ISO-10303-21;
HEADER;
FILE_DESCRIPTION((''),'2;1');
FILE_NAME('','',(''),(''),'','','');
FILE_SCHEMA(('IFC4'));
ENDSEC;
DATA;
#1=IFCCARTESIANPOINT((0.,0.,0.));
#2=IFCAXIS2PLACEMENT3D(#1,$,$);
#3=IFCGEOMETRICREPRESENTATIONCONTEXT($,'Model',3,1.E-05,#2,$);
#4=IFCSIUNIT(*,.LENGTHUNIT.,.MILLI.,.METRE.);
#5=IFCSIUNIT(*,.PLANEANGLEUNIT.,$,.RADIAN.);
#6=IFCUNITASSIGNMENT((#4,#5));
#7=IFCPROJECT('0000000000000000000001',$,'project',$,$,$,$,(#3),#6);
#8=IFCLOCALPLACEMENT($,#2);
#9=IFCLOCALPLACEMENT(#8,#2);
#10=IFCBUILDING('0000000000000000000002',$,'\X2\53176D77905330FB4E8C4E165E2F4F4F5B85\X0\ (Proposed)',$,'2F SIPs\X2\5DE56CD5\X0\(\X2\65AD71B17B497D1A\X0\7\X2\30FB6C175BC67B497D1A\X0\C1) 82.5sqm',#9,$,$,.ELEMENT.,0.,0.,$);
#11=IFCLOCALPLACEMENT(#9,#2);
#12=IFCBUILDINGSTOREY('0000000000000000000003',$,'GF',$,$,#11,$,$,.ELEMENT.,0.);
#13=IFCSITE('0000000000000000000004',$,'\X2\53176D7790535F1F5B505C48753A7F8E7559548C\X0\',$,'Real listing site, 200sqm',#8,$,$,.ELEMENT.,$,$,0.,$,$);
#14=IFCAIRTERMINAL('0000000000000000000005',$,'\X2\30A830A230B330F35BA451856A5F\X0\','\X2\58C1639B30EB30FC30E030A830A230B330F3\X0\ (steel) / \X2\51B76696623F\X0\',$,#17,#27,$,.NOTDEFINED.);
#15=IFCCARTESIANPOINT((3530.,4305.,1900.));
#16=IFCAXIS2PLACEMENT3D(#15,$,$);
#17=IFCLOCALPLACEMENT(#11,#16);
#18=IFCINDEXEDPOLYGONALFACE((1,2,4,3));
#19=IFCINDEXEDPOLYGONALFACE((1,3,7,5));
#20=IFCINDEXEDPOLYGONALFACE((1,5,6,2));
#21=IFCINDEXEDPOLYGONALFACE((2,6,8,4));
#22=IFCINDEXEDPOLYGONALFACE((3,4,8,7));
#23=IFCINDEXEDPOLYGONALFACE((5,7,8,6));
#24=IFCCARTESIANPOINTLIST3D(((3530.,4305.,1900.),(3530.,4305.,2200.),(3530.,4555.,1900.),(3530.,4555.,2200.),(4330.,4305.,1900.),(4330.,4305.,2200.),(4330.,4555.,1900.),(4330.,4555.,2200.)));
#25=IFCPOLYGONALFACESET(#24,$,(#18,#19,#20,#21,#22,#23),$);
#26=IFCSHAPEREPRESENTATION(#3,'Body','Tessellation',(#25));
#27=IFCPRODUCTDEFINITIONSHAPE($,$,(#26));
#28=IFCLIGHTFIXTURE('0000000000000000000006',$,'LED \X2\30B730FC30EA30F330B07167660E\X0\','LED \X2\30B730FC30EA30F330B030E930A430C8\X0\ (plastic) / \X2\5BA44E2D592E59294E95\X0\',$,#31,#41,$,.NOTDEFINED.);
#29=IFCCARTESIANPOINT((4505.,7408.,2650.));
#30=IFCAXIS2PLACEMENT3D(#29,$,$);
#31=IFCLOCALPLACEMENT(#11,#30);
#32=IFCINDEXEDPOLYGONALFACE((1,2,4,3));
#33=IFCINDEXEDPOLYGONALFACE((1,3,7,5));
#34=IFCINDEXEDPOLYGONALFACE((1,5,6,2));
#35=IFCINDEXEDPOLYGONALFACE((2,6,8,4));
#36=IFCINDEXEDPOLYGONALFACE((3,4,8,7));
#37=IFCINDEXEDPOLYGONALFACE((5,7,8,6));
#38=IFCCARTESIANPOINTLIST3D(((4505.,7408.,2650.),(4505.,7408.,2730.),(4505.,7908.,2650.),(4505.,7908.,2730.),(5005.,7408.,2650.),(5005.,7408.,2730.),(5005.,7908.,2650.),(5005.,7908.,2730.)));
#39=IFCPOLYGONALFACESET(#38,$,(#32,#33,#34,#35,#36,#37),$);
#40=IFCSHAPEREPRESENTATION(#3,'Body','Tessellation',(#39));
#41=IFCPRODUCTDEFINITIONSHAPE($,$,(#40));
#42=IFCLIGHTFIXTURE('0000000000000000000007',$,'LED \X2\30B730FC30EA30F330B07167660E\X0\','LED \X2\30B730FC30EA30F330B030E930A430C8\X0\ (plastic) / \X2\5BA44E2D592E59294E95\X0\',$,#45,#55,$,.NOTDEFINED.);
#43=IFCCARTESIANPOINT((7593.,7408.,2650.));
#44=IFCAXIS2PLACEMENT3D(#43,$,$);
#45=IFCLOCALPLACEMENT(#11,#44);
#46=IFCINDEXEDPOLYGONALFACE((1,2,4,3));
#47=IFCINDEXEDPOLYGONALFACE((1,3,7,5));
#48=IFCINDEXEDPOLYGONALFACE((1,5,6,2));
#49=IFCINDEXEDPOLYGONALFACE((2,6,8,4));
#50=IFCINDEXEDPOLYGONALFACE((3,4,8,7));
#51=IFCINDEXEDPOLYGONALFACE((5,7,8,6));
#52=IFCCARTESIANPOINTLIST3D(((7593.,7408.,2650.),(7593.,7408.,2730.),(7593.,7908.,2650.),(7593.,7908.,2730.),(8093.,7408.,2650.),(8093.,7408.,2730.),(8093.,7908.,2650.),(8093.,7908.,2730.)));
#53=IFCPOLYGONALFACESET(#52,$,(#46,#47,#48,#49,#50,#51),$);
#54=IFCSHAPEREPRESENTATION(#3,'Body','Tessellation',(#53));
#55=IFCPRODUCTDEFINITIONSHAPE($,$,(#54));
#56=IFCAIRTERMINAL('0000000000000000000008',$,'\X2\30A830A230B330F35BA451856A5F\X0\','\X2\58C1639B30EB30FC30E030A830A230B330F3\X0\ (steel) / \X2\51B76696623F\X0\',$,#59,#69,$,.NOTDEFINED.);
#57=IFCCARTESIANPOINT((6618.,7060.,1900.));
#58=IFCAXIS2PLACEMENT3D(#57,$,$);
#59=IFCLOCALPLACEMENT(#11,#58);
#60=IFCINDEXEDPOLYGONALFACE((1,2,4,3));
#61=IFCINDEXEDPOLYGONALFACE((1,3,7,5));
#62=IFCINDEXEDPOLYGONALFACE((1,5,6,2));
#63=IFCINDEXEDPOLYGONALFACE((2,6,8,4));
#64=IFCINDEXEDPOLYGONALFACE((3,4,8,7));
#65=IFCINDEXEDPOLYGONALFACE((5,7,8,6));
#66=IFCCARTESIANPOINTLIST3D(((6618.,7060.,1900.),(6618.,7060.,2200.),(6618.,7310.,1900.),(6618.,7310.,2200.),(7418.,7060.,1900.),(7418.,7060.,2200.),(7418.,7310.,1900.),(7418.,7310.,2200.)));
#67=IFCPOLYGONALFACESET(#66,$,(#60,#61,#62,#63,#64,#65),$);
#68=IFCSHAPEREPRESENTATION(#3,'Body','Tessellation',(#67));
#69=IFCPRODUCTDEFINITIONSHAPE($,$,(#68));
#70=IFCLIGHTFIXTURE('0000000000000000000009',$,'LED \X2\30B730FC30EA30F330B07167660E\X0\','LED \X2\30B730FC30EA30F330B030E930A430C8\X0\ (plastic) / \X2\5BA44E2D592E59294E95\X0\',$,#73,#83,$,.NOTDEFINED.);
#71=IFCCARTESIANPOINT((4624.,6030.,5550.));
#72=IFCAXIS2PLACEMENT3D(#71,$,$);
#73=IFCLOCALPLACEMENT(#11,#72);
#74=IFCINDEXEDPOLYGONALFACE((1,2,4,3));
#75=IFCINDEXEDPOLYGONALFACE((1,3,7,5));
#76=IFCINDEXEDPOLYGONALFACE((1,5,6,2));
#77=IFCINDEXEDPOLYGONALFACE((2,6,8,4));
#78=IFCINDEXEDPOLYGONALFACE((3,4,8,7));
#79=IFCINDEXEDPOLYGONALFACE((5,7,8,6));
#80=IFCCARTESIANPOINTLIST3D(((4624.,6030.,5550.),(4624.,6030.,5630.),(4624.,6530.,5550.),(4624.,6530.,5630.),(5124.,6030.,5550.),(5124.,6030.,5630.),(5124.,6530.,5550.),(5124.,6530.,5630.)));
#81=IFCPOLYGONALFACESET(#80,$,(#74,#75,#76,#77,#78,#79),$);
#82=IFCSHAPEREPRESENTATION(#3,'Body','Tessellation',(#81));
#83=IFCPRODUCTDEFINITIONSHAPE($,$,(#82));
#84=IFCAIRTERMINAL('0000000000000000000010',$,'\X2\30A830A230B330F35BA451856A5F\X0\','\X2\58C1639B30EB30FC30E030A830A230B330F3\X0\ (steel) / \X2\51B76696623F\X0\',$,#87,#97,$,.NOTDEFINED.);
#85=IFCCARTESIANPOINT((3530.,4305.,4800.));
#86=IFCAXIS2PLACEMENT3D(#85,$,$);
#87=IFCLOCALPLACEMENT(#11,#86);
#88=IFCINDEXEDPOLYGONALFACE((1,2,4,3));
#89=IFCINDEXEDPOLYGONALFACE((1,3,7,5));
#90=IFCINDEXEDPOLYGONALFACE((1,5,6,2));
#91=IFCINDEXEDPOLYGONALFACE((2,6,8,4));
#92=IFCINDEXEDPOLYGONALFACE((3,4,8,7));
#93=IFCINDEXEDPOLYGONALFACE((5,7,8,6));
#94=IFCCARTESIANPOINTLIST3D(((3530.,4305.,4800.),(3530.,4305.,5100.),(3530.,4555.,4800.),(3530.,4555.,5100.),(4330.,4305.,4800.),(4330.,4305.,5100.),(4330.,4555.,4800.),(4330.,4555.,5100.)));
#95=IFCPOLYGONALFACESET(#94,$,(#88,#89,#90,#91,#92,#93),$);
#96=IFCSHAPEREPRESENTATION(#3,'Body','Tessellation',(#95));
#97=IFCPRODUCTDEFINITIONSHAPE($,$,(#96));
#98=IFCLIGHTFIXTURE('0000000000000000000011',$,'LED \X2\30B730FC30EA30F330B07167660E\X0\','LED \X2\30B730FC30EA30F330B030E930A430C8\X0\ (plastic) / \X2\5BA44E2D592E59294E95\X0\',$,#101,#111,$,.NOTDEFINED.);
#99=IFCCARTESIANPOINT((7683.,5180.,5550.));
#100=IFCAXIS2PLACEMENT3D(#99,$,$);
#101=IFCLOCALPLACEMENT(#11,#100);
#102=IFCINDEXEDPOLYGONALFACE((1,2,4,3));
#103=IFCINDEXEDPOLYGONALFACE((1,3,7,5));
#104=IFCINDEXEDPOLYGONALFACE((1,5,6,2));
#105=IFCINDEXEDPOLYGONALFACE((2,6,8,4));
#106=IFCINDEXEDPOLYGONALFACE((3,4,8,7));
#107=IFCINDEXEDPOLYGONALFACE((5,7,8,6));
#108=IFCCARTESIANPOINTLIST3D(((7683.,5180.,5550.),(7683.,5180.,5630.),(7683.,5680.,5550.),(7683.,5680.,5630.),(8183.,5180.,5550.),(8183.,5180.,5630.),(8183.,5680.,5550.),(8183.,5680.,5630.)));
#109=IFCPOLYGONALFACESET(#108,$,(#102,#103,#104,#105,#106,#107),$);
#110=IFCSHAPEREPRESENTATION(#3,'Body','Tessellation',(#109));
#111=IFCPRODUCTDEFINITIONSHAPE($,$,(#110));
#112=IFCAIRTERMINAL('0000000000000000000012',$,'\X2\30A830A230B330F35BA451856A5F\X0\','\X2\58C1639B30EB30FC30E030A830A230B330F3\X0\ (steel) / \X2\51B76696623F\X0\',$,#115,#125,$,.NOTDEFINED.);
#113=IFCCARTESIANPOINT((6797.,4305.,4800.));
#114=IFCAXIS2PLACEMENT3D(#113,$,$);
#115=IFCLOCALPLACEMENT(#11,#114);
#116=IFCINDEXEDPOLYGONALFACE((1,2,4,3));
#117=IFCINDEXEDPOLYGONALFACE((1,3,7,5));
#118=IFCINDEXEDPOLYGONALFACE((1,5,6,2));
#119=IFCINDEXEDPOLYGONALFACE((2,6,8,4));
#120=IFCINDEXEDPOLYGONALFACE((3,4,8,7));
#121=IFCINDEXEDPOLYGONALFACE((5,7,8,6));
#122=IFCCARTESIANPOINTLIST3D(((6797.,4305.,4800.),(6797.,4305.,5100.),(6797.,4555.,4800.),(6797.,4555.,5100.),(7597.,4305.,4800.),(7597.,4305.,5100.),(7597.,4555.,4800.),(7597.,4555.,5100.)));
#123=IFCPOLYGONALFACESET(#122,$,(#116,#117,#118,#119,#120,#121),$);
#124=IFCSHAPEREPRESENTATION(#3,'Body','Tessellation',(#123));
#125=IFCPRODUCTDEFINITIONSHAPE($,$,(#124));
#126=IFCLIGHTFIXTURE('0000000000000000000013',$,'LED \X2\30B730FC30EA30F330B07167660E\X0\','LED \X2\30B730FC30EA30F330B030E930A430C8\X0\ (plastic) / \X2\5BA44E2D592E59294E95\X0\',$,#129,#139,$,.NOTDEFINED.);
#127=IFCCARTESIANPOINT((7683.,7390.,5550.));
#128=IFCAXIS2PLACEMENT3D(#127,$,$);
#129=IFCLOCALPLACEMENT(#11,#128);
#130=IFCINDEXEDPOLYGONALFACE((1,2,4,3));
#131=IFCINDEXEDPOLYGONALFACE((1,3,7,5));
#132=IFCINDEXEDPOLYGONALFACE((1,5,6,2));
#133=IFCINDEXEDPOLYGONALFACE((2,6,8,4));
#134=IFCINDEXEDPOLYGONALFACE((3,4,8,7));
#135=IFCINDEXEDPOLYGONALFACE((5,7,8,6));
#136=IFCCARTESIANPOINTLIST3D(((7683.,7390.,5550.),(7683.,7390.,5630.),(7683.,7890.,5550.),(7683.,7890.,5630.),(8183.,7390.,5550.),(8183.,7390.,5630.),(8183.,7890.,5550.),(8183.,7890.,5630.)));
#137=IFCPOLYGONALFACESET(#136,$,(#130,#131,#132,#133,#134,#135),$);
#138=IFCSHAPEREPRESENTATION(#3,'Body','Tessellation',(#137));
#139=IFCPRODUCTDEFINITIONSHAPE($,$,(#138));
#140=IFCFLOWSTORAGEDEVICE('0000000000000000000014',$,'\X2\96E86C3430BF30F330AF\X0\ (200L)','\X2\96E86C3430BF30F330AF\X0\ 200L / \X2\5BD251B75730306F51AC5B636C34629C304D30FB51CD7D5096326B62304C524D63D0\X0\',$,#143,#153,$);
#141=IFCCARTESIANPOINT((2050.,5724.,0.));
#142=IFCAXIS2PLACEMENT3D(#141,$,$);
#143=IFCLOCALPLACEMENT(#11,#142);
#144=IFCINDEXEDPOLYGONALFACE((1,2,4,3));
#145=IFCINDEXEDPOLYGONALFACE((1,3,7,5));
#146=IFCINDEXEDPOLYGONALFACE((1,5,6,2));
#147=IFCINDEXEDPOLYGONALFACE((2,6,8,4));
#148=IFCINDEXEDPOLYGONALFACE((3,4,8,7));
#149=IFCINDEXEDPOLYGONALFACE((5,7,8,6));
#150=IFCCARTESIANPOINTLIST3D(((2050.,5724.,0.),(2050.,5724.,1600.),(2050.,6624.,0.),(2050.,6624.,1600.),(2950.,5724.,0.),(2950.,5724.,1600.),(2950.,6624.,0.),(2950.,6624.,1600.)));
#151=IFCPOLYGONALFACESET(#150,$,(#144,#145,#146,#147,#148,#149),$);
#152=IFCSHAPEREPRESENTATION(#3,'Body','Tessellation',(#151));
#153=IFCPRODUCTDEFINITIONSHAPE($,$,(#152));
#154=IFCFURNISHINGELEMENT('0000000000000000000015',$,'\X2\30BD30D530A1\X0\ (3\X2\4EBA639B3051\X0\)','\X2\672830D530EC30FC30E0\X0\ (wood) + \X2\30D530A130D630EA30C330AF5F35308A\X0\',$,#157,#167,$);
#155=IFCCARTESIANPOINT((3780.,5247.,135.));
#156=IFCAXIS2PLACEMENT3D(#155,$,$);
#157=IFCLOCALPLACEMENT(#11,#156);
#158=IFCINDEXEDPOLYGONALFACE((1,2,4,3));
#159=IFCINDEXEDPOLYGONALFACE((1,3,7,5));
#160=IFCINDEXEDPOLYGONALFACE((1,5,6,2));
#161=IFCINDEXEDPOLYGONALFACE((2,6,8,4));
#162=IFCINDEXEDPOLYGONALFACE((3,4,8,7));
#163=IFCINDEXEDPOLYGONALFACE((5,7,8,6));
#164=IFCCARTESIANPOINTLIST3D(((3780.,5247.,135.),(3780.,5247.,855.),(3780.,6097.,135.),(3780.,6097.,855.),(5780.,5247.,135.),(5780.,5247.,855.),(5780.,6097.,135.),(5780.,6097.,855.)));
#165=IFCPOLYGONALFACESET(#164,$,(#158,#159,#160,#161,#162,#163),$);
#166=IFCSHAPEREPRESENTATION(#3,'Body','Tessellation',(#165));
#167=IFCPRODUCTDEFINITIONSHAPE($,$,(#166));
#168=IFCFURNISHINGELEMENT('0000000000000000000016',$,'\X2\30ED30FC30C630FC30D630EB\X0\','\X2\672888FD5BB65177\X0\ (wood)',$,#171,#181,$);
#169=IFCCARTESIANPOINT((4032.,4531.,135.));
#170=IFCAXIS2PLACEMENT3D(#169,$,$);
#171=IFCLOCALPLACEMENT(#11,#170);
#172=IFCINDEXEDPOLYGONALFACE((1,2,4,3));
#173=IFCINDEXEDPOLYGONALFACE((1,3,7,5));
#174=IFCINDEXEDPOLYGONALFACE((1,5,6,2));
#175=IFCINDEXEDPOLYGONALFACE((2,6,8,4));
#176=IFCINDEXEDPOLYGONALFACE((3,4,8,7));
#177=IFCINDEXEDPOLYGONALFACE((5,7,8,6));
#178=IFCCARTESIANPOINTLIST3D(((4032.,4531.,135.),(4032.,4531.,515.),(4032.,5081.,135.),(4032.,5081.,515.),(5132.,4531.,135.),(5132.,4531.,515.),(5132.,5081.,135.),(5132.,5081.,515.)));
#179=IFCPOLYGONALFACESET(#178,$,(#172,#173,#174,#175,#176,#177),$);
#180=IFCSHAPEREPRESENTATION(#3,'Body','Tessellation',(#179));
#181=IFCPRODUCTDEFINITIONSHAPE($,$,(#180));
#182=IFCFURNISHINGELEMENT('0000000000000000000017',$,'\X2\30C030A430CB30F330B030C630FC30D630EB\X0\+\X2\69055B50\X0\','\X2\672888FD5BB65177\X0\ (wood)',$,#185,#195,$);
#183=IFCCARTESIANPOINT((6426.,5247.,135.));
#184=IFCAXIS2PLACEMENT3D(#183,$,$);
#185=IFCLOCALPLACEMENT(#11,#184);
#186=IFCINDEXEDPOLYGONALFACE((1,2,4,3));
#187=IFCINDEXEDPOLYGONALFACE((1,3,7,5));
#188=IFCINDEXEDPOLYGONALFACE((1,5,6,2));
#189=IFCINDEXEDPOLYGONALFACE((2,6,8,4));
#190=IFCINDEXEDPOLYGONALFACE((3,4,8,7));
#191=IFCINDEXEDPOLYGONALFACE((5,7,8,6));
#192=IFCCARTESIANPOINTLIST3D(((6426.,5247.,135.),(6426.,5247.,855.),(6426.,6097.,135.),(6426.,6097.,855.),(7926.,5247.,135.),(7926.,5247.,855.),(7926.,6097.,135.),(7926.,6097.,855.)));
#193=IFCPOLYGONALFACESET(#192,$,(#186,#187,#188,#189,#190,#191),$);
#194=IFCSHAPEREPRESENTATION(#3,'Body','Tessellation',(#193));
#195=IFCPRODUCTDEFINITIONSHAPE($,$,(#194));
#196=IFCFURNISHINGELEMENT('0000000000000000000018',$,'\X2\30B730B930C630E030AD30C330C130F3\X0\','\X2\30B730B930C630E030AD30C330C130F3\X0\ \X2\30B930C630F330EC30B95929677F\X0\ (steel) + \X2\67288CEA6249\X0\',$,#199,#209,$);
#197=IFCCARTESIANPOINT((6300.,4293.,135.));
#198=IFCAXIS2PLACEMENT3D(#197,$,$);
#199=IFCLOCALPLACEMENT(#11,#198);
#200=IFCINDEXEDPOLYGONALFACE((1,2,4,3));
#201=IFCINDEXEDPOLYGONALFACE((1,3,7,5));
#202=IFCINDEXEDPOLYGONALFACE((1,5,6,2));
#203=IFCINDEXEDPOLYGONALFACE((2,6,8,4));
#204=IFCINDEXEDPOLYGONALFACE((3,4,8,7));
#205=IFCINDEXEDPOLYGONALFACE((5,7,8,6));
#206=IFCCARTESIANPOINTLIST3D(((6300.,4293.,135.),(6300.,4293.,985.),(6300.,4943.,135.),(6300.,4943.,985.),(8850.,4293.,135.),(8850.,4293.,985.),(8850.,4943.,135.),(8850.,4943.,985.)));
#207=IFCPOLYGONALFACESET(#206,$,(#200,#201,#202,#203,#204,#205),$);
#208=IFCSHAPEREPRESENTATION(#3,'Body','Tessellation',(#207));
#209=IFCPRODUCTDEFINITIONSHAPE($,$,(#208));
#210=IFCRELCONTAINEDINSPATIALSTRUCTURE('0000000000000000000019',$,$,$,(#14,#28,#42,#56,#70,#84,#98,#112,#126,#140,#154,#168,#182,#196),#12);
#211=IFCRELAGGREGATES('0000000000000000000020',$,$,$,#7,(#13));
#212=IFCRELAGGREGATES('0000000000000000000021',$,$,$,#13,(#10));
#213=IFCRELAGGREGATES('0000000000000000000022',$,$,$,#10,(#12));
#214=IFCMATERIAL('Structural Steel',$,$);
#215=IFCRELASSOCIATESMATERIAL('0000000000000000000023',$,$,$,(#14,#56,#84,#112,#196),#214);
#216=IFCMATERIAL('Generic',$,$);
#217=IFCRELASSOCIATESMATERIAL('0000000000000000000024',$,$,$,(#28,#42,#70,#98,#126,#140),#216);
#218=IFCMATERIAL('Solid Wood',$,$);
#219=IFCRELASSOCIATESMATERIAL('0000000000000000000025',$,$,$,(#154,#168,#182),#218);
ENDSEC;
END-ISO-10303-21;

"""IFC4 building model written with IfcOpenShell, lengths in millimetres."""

from ifc_helpers import new_model, si_unit, frame, frame_2d, origin, place, context, project, spatial, rectangle, extrude, material, element, save


model = new_model("IFC4")

# Units and contexts
model_context = context("Model", 3, precision=1e-05, world=origin())
ifc_project = project(units=[si_unit("LENGTHUNIT", "METRE", prefix="MILLI"), si_unit("PLANEANGLEUNIT", "RADIAN")], contexts=[model_context])

# Site, building, storey
site_placement = place(None, origin())
site = spatial("IfcSite", under=ifc_project, at=site_placement, Name="北海道弟子屈町美留和", ObjectType="Real listing site, 200sqm", CompositionType="ELEMENT", RefElevation=0.0)
building_placement = place(site_placement, origin())
building = spatial("IfcBuilding", under=site, at=building_placement, Name="北海道・二世帯住宅 (Proposed)", ObjectType="2F SIPs工法(断熱等級7・気密等級C1) 82.5sqm", CompositionType="ELEMENT", ElevationOfRefHeight=0.0, ElevationOfTerrain=0.0)
storey_placement = place(building_placement, origin())
storey = spatial("IfcBuildingStorey", under=building, at=storey_placement, Name="GF", CompositionType="ELEMENT", Elevation=0.0)

# Shared definitions
ifc_material_1 = material(Name="Solid Wood")

# Shared definitions
ifc_material_2 = material(Name="Structural Steel")

# Shared definitions
ifc_material_3 = material(Name="Generic")

# Air terminal
air_terminal_1_placement = place(storey_placement, frame((3530.0, 4305.0, 1900.0)))
element("IfcAirTerminal", 1, at=air_terminal_1_placement, inside=storey, material=ifc_material_2, Name="エアコン室内機", Description="壁掛ルームエアコン (steel) / 冷暖房", PredefinedType="NOTDEFINED", context=model_context, shape_type="SweptSolid", body=[
    extrude(rectangle(XDim=800.0, YDim=250.0, at=frame_2d((400.0, 125.0))), frame((3530.0, 4305.0, 1900.0)), (0.0, 0.0, 1.0), 300.0),
])

# Light fixtures
light_fixture_1_placement = place(storey_placement, frame((4505.0, 7408.0, 2650.0)))
element("IfcLightFixture", 2, at=light_fixture_1_placement, inside=storey, material=ifc_material_3, Name="LED シーリング照明", Description="LED シーリングライト (plastic) / 室中央天井", PredefinedType="NOTDEFINED", context=model_context, shape_type="SweptSolid", body=[
    extrude(rectangle(XDim=500.0, YDim=500.0, at=frame_2d((250.0, 250.0))), frame((4505.0, 7408.0, 2650.0)), (0.0, 0.0, 1.0), 80.0),
])
light_fixture_2_placement = place(storey_placement, frame((7593.0, 7408.0, 2650.0)))
element("IfcLightFixture", 3, at=light_fixture_2_placement, inside=storey, material=ifc_material_3, Name="LED シーリング照明", Description="LED シーリングライト (plastic) / 室中央天井", PredefinedType="NOTDEFINED", context=model_context, shape_type="SweptSolid", body=[
    extrude(rectangle(XDim=500.0, YDim=500.0, at=frame_2d((250.0, 250.0))), frame((7593.0, 7408.0, 2650.0)), (0.0, 0.0, 1.0), 80.0),
])

# Air terminal
air_terminal_2_placement = place(storey_placement, frame((6618.0, 7060.0, 1900.0)))
element("IfcAirTerminal", 4, at=air_terminal_2_placement, inside=storey, material=ifc_material_2, Name="エアコン室内機", Description="壁掛ルームエアコン (steel) / 冷暖房", PredefinedType="NOTDEFINED", context=model_context, shape_type="SweptSolid", body=[
    extrude(rectangle(XDim=800.0, YDim=250.0, at=frame_2d((400.0, 125.0))), frame((6618.0, 7060.0, 1900.0)), (0.0, 0.0, 1.0), 300.0),
])

# Light fixture
light_fixture_3_placement = place(storey_placement, frame((4624.0, 6030.0, 5550.0)))
element("IfcLightFixture", 5, at=light_fixture_3_placement, inside=storey, material=ifc_material_3, Name="LED シーリング照明", Description="LED シーリングライト (plastic) / 室中央天井", PredefinedType="NOTDEFINED", context=model_context, shape_type="SweptSolid", body=[
    extrude(rectangle(XDim=500.0, YDim=500.0, at=frame_2d((250.0, 250.0))), frame((4624.0, 6030.0, 5550.0)), (0.0, 0.0, 1.0), 80.0),
])

# Air terminal
air_terminal_3_placement = place(storey_placement, frame((3530.0, 4305.0, 4800.0)))
element("IfcAirTerminal", 6, at=air_terminal_3_placement, inside=storey, material=ifc_material_2, Name="エアコン室内機", Description="壁掛ルームエアコン (steel) / 冷暖房", PredefinedType="NOTDEFINED", context=model_context, shape_type="SweptSolid", body=[
    extrude(rectangle(XDim=800.0, YDim=250.0, at=frame_2d((400.0, 125.0))), frame((3530.0, 4305.0, 4800.0)), (0.0, 0.0, 1.0), 300.0),
])

# Light fixture
light_fixture_4_placement = place(storey_placement, frame((7683.0, 5180.0, 5550.0)))
element("IfcLightFixture", 7, at=light_fixture_4_placement, inside=storey, material=ifc_material_3, Name="LED シーリング照明", Description="LED シーリングライト (plastic) / 室中央天井", PredefinedType="NOTDEFINED", context=model_context, shape_type="SweptSolid", body=[
    extrude(rectangle(XDim=500.0, YDim=500.0, at=frame_2d((250.0, 250.0))), frame((7683.0, 5180.0, 5550.0)), (0.0, 0.0, 1.0), 80.0),
])

# Air terminal
air_terminal_4_placement = place(storey_placement, frame((6797.0, 4305.0, 4800.0)))
element("IfcAirTerminal", 8, at=air_terminal_4_placement, inside=storey, material=ifc_material_2, Name="エアコン室内機", Description="壁掛ルームエアコン (steel) / 冷暖房", PredefinedType="NOTDEFINED", context=model_context, shape_type="SweptSolid", body=[
    extrude(rectangle(XDim=800.0, YDim=250.0, at=frame_2d((400.0, 125.0))), frame((6797.0, 4305.0, 4800.0)), (0.0, 0.0, 1.0), 300.0),
])

# Light fixture
light_fixture_5_placement = place(storey_placement, frame((7683.0, 7390.0, 5550.0)))
element("IfcLightFixture", 9, at=light_fixture_5_placement, inside=storey, material=ifc_material_3, Name="LED シーリング照明", Description="LED シーリングライト (plastic) / 室中央天井", PredefinedType="NOTDEFINED", context=model_context, shape_type="SweptSolid", body=[
    extrude(rectangle(XDim=500.0, YDim=500.0, at=frame_2d((250.0, 250.0))), frame((7683.0, 7390.0, 5550.0)), (0.0, 0.0, 1.0), 80.0),
])

# Flow storage device
flow_storage_device_1_placement = place(storey_placement, frame((2050.0, 5724.0, 0.0)))
element("IfcFlowStorageDevice", 10, at=flow_storage_device_1_placement, inside=storey, material=ifc_material_3, Name="雨水タンク (200L)", Description="雨水タンク 200L / 寒冷地は冬季水抜き・凍結防止が前提", context=model_context, shape_type="SweptSolid", body=[
    extrude(rectangle(XDim=900.0, YDim=900.0, at=frame_2d((450.0, 450.0))), frame((2050.0, 5724.0, 0.0)), (0.0, 0.0, 1.0), 1600.0),
])

# Furnishing elements
furnishing_1_placement = place(storey_placement, frame((3780.0, 5247.0, 135.0)))
element("IfcFurnishingElement", 11, at=furnishing_1_placement, inside=storey, material=ifc_material_1, Name="ソファ (3人掛け)", Description="木フレーム (wood) + ファブリック張り", context=model_context, shape_type="SweptSolid", body=[
    extrude(rectangle(XDim=2000.0, YDim=850.0, at=frame_2d((1000.0, 425.0))), frame((3780.0, 5247.0, 135.0)), (0.0, 0.0, 1.0), 720.0),
])
furnishing_2_placement = place(storey_placement, frame((4032.0, 4531.0, 135.0)))
element("IfcFurnishingElement", 12, at=furnishing_2_placement, inside=storey, material=ifc_material_1, Name="ローテーブル", Description="木製家具 (wood)", context=model_context, shape_type="SweptSolid", body=[
    extrude(rectangle(XDim=1100.0, YDim=550.0, at=frame_2d((550.0, 275.0))), frame((4032.0, 4531.0, 135.0)), (0.0, 0.0, 1.0), 380.0),
])
furnishing_3_placement = place(storey_placement, frame((6426.0, 5247.0, 135.0)))
element("IfcFurnishingElement", 13, at=furnishing_3_placement, inside=storey, material=ifc_material_1, Name="ダイニングテーブル+椅子", Description="木製家具 (wood)", context=model_context, shape_type="SweptSolid", body=[
    extrude(rectangle(XDim=1500.0, YDim=850.0, at=frame_2d((750.0, 425.0))), frame((6426.0, 5247.0, 135.0)), (0.0, 0.0, 1.0), 720.0),
])
furnishing_4_placement = place(storey_placement, frame((6300.0, 4293.0, 135.0)))
element("IfcFurnishingElement", 14, at=furnishing_4_placement, inside=storey, material=ifc_material_2, Name="システムキッチン", Description="システムキッチン ステンレス天板 (steel) + 木質扉", context=model_context, shape_type="SweptSolid", body=[
    extrude(rectangle(XDim=2550.0, YDim=650.0, at=frame_2d((1275.0, 325.0))), frame((6300.0, 4293.0, 135.0)), (0.0, 0.0, 1.0), 850.0),
])

save(model, "model.ifc")
